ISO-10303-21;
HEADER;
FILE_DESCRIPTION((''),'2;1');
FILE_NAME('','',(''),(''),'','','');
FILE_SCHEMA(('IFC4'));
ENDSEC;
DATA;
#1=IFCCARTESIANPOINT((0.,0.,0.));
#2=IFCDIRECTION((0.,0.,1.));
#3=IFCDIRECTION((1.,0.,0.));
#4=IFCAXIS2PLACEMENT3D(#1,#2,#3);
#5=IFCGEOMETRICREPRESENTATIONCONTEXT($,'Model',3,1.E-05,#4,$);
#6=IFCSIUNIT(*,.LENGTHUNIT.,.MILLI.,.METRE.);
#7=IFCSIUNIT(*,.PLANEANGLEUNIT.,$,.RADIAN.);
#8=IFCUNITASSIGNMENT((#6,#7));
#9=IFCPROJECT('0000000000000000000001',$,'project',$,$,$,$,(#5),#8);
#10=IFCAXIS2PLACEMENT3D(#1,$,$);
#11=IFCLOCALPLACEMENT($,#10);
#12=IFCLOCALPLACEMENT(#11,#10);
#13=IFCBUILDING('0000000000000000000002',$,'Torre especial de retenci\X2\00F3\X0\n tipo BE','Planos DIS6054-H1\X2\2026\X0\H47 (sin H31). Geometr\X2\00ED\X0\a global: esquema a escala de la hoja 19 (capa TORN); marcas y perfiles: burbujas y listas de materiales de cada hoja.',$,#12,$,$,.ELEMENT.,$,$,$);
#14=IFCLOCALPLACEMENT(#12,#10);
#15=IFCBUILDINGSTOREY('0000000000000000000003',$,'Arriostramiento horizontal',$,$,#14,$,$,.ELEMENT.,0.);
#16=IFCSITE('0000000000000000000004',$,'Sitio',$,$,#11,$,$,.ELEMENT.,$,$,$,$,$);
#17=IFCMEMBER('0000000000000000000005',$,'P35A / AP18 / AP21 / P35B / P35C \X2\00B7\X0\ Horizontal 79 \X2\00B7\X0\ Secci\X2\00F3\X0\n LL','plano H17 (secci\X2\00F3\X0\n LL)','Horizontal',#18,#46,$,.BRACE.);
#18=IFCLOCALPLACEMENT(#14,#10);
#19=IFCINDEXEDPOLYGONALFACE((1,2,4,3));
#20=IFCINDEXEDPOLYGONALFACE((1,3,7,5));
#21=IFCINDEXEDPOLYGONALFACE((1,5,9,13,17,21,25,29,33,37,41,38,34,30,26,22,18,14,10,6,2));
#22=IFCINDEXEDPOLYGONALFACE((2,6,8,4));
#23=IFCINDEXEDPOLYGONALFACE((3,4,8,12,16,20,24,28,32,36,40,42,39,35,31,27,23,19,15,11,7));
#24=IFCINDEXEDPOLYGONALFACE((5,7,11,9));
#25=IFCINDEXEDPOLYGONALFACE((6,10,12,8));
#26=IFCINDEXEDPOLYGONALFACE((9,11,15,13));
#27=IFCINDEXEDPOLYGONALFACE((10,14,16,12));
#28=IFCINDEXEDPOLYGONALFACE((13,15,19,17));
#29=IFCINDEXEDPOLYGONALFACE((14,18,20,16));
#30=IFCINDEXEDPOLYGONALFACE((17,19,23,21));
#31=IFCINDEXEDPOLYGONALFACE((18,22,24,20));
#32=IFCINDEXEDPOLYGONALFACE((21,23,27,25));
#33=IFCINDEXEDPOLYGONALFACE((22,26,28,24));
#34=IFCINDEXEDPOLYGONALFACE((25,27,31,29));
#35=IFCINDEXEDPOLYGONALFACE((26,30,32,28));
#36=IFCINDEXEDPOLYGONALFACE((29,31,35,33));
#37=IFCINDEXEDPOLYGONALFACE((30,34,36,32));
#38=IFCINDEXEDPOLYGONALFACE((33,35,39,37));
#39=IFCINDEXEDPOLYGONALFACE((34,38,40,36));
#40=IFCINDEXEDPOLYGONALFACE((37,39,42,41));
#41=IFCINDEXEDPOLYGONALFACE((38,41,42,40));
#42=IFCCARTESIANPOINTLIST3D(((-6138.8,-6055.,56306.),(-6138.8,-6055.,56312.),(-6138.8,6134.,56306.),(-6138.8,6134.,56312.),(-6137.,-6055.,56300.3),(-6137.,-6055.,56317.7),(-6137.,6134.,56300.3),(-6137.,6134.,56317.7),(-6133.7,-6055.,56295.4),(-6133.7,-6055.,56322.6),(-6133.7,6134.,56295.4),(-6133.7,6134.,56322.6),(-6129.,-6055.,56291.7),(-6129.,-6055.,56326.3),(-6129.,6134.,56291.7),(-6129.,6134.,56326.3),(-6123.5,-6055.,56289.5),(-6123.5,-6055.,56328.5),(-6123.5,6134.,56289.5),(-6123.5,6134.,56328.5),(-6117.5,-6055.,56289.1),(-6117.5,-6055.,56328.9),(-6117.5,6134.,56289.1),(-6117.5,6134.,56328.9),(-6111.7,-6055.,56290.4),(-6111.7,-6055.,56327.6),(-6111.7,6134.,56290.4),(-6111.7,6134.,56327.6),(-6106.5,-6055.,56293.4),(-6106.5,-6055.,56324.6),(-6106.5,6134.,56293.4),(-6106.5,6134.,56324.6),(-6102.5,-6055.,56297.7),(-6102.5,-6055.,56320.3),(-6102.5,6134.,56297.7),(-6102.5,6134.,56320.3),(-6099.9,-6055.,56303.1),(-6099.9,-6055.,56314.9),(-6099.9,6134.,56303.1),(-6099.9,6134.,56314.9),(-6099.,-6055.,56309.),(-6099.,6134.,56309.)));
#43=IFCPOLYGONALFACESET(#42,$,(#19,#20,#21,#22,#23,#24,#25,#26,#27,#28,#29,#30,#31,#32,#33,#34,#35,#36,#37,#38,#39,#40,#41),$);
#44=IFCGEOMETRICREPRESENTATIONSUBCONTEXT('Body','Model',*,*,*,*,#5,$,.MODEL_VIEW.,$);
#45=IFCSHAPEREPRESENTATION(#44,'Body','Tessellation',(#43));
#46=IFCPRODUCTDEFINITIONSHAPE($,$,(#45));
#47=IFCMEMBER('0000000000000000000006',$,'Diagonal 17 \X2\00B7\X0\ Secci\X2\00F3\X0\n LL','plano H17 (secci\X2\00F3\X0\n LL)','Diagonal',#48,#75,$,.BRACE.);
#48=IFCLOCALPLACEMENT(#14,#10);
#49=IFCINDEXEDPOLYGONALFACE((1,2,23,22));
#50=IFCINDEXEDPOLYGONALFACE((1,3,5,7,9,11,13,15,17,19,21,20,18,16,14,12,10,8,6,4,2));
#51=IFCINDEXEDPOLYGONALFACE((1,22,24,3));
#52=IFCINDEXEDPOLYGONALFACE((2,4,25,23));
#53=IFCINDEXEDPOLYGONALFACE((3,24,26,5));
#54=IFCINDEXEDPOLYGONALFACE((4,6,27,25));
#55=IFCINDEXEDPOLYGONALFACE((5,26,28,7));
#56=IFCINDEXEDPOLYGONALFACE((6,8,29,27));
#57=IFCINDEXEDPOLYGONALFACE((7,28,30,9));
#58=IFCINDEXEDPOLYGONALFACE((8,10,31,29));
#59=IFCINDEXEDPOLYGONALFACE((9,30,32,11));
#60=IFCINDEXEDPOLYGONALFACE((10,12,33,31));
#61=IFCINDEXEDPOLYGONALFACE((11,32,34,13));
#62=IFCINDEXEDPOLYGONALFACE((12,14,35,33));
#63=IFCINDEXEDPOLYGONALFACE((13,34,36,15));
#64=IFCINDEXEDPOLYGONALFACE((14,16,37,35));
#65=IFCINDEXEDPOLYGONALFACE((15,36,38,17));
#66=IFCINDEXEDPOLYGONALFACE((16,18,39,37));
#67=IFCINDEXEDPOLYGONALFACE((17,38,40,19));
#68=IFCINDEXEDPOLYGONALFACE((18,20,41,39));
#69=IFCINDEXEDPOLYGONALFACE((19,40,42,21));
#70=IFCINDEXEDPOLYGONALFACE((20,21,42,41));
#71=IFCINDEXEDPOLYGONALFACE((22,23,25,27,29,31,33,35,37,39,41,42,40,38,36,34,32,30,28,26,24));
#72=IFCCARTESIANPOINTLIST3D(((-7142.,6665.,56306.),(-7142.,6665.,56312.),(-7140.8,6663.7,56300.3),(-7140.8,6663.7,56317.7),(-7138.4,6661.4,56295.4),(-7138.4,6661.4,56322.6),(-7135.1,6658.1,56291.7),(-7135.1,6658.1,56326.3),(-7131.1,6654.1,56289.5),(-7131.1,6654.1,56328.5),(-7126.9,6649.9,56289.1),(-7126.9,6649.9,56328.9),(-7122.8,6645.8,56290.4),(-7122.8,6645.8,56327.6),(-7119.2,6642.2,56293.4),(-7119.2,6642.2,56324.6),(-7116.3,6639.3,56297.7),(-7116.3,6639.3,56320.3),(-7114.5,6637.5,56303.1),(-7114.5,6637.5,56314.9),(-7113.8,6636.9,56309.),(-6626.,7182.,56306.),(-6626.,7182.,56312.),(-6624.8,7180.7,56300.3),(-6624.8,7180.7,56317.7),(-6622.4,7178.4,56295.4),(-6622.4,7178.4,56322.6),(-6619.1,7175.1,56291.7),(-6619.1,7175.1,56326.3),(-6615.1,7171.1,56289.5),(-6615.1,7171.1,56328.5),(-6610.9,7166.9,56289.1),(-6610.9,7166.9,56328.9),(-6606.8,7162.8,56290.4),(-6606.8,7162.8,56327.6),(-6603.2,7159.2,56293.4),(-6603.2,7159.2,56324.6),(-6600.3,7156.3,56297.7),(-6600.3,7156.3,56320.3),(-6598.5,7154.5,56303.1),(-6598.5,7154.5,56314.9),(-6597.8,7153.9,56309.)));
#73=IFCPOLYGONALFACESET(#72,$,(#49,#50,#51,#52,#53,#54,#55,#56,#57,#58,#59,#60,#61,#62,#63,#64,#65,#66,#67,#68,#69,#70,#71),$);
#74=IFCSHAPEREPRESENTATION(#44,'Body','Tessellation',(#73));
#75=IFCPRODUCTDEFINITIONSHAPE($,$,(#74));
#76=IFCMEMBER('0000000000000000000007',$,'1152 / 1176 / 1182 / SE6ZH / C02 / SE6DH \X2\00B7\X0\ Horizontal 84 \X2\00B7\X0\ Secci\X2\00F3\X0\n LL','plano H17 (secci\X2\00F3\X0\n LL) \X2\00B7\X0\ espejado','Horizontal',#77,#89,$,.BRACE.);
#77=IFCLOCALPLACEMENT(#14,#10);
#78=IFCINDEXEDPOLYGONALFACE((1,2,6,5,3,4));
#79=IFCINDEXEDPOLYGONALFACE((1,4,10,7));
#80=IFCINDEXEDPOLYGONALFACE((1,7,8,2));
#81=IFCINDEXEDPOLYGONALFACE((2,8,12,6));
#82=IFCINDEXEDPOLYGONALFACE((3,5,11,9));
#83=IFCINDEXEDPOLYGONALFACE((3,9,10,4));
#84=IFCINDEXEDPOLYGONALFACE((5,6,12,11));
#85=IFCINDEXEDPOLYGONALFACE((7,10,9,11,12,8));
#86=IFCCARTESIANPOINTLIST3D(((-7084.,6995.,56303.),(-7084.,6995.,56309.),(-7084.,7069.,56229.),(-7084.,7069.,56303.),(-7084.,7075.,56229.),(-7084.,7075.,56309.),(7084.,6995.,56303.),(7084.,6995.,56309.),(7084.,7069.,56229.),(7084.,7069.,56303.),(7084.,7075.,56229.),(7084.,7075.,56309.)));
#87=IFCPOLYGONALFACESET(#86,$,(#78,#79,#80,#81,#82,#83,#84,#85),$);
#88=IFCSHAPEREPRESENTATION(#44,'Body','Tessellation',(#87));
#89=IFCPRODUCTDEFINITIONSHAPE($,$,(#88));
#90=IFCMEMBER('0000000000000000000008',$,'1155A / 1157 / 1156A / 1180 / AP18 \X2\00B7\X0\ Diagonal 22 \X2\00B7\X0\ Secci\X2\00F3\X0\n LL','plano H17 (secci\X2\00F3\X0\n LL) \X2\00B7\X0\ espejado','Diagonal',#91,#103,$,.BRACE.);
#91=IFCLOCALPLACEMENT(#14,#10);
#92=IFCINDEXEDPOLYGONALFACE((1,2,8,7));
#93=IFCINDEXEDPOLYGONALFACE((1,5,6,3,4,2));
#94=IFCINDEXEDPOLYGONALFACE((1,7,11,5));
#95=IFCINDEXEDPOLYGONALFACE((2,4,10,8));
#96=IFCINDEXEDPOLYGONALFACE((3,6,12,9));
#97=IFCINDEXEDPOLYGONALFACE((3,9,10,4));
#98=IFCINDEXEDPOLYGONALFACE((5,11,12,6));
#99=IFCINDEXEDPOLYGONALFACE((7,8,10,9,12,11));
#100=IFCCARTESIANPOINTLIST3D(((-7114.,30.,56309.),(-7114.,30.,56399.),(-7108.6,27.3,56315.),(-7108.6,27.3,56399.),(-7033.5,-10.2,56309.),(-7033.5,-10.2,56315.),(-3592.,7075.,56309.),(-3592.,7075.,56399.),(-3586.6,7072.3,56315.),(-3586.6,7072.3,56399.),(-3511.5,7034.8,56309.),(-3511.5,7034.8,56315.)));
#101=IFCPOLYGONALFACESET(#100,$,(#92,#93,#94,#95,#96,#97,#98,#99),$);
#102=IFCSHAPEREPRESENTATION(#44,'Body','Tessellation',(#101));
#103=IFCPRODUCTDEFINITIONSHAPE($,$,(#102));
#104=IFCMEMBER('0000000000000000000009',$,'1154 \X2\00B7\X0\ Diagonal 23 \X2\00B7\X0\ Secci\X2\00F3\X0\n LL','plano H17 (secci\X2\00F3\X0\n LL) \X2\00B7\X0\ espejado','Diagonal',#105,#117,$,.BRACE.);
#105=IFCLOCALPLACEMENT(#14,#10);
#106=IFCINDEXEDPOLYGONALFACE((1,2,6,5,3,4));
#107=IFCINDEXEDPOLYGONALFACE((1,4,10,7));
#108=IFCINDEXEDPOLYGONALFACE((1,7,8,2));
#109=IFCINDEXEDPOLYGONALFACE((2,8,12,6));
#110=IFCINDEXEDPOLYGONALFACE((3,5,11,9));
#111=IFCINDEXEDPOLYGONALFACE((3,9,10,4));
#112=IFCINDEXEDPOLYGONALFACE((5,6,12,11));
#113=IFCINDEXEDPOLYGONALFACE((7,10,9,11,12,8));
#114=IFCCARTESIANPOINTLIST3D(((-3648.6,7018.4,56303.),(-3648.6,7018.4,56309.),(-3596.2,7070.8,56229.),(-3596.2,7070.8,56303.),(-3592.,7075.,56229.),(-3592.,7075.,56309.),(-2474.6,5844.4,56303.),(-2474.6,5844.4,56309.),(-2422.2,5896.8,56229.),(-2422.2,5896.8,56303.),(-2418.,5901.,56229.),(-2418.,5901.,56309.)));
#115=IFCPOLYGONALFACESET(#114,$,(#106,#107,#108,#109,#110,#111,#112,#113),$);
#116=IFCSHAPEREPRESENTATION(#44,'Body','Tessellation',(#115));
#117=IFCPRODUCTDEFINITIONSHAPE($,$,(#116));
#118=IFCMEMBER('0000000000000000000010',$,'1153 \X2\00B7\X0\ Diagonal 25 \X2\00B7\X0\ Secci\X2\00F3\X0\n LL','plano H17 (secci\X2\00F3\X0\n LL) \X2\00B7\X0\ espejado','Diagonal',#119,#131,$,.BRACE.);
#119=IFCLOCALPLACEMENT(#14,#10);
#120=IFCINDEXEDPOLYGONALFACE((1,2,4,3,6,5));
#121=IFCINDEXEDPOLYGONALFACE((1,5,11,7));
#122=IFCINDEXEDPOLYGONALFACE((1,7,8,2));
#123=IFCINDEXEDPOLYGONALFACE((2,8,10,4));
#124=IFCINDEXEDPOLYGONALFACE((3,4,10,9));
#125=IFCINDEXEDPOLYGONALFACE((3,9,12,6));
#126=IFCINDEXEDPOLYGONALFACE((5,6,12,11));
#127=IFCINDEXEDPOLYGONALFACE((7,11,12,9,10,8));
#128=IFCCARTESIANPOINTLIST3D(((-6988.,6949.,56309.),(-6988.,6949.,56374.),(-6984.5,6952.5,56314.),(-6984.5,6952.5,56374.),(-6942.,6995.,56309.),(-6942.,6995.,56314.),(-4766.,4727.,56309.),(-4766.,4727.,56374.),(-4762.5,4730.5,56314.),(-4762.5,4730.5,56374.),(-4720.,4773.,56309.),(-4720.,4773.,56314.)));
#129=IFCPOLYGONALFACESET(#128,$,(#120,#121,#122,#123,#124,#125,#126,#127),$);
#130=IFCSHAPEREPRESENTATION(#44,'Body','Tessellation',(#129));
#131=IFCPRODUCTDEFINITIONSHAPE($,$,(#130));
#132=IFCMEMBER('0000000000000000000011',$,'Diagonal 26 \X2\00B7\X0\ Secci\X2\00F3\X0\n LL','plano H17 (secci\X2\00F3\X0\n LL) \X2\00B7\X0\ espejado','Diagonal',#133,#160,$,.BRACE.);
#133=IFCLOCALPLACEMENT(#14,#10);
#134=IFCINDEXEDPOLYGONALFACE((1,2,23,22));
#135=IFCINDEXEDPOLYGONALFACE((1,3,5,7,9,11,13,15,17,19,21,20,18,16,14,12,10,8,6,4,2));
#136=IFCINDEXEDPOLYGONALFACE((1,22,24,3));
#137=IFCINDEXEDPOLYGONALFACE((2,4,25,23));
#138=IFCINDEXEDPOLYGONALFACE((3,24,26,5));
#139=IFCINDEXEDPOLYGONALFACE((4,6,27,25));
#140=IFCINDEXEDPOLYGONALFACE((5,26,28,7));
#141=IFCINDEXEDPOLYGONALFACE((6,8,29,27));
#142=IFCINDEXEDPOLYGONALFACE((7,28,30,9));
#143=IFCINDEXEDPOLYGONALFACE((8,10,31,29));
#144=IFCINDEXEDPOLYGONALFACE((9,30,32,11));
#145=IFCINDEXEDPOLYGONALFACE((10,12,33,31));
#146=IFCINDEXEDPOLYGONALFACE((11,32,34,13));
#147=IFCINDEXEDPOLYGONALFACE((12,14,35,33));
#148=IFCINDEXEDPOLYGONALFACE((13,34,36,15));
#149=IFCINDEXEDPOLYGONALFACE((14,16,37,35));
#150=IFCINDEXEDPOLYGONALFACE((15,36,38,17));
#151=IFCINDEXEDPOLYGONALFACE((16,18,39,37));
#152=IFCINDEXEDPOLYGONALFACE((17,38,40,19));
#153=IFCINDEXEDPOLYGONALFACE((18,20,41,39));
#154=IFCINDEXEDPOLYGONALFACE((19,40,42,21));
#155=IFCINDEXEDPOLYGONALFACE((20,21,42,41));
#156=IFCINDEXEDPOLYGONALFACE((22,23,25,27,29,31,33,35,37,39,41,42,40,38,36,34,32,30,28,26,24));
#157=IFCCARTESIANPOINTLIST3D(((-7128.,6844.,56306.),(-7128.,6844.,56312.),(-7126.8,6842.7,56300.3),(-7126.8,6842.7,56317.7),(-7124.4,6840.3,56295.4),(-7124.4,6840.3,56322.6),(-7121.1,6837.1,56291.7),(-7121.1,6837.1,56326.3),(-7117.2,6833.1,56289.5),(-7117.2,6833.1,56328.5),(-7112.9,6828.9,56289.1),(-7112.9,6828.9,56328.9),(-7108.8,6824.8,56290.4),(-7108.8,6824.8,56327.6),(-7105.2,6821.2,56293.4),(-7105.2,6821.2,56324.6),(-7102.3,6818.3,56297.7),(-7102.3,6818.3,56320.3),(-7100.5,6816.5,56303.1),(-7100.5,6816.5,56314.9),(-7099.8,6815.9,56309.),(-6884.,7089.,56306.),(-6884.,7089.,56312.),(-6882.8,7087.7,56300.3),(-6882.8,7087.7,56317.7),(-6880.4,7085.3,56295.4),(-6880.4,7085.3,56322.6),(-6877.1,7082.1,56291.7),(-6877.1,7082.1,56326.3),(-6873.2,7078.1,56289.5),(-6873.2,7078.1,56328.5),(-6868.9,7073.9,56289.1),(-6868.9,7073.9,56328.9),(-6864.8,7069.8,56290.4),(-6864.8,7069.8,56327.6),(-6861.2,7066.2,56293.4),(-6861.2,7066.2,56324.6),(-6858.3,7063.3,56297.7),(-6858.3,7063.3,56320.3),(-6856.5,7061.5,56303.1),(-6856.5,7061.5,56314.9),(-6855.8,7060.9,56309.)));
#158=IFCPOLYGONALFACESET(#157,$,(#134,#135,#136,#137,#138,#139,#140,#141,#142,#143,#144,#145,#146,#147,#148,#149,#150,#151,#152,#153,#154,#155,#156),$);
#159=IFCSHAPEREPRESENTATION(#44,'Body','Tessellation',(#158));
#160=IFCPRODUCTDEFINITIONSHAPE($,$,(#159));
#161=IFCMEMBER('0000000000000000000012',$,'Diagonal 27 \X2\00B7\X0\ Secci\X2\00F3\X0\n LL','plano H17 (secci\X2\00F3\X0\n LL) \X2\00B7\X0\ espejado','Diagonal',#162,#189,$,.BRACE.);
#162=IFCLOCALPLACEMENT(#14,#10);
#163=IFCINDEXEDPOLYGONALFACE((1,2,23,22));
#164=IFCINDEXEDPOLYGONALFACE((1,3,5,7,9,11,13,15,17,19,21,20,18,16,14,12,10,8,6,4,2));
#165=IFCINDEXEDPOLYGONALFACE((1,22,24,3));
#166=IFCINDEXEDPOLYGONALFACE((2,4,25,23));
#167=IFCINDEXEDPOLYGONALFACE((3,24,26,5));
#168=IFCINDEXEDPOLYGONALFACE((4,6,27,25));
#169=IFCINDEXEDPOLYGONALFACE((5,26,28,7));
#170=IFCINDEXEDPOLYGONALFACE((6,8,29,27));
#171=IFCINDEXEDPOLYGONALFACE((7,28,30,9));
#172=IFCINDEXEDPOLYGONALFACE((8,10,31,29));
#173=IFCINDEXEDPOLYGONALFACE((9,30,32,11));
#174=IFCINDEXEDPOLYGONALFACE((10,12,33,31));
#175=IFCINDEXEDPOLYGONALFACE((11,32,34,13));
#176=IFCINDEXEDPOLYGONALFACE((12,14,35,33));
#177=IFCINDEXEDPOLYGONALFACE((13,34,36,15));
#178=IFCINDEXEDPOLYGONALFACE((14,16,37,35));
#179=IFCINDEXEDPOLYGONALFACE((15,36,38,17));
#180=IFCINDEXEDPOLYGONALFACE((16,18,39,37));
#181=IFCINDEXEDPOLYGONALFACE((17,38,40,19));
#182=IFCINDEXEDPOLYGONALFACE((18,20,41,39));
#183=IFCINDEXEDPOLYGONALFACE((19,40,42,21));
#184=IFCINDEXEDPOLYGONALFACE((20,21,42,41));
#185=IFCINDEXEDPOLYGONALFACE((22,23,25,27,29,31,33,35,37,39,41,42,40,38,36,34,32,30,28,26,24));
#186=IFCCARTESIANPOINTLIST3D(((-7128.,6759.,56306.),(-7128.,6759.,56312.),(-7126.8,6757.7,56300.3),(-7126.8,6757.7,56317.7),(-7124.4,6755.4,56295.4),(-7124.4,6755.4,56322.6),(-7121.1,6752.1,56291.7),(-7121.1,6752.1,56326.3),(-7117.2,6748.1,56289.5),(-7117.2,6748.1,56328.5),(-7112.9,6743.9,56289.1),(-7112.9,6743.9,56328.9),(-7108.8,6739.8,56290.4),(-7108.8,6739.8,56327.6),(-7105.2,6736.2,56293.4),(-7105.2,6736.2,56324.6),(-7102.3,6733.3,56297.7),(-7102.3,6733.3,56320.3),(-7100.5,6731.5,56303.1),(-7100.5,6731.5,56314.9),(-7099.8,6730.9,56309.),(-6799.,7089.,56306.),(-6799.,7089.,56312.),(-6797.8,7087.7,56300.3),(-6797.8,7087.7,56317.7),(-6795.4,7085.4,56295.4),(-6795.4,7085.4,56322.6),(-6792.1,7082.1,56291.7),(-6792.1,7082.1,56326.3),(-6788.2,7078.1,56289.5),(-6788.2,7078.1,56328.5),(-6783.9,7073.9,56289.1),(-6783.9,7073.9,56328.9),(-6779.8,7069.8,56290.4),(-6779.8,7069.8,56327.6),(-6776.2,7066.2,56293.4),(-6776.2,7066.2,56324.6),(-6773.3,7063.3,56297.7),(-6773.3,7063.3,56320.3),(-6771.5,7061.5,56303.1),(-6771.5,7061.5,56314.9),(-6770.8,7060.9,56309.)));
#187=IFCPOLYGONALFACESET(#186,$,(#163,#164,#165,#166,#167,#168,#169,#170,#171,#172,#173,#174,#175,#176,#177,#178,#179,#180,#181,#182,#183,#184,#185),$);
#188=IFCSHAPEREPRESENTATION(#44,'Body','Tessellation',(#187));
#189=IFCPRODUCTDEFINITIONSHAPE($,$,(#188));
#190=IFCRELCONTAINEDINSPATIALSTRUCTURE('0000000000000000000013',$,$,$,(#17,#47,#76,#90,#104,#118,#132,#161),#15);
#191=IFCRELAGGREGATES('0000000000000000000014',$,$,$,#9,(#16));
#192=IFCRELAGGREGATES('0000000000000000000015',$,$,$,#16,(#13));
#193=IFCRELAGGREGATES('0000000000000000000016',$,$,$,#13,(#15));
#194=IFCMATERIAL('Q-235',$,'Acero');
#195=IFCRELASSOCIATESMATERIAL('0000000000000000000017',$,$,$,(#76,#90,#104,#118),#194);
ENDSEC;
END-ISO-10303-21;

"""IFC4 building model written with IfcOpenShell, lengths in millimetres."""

from ifc_helpers import new_model, si_unit, frame, frame_2d, origin, origin_with_axes, place, context, subcontext, project, spatial, circle, l_section, extrude, material, element, save


model = new_model("IFC4")

# Units and contexts
model_context = context("Model", 3, precision=1e-05, world=origin_with_axes())
body_context = subcontext(model_context, "Body", "Model", "MODEL_VIEW")
ifc_project = project(units=[si_unit("LENGTHUNIT", "METRE", prefix="MILLI"), si_unit("PLANEANGLEUNIT", "RADIAN")], contexts=[model_context])

# Site, building, storey
site_placement = place(None, origin())
site = spatial("IfcSite", under=ifc_project, at=site_placement, Name="Sitio", CompositionType="ELEMENT")
building_placement = place(site_placement, origin())
building = spatial("IfcBuilding", under=site, at=building_placement, Name="Torre especial de retención tipo BE", Description="Planos DIS6054-H1…H47 (sin H31). Geometría global: esquema a escala de la hoja 19 (capa TORN); marcas y perfiles: burbujas y listas de materiales de cada hoja.", CompositionType="ELEMENT")
storey_placement = place(building_placement, origin())
storey = spatial("IfcBuildingStorey", under=building, at=storey_placement, Name="Arriostramiento horizontal", CompositionType="ELEMENT", Elevation=0.0)

# Members
member_1_placement = place(storey_placement, frame((-6119.0, 6134.0, 56309.0), z_axis=(0.0, -1.0, 0.0), x_axis=(1.0, 0.0, 0.0)))
element("IfcMember", 1, at=member_1_placement, inside=storey, Name="P35A / AP18 / AP21 / P35B / P35C · Horizontal 79 · Sección LL", Description="plano H17 (sección LL)", ObjectType="Horizontal", PredefinedType="BRACE", context=body_context, shape_type="SweptSolid", body=[
    extrude(circle(Radius=20.0), None, (0.0, 0.0, 1.0), 12189.0),
])
member_2_placement = place(storey_placement, frame((-6612.0, 7168.0, 56309.0), z_axis=(-0.706422, -0.707791, 0.0), x_axis=(0.707791, -0.706422, 0.0)))
element("IfcMember", 2, at=member_2_placement, inside=storey, Name="Diagonal 17 · Sección LL", Description="plano H17 (sección LL)", ObjectType="Diagonal", PredefinedType="BRACE", context=body_context, shape_type="SweptSolid", body=[
    extrude(circle(Radius=20.0), None, (0.0, 0.0, 1.0), 730.4),
])
ifc_material = material(Name="Q-235", Category="Acero")
member_3_placement = place(storey_placement, frame((-7084.0, 7075.0, 56309.0), z_axis=(1.0, 0.0, 0.0), x_axis=(0.0, -1.0, 0.0)))
element("IfcMember", 3, at=member_3_placement, inside=storey, material=ifc_material, Name="1152 / 1176 / 1182 / SE6ZH / C02 / SE6DH · Horizontal 84 · Sección LL", Description="plano H17 (sección LL) · espejado", ObjectType="Horizontal", PredefinedType="BRACE", context=body_context, shape_type="SweptSolid", body=[
    extrude(l_section(Depth=80.0, Width=80.0, Thickness=6.0, at=frame_2d((40.0, 40.0))), None, (0.0, 0.0, 1.0), 14168.0),
])
member_4_placement = place(storey_placement, frame((-3592.0, 7075.0, 56309.0), z_axis=(-0.447163, -0.894453, 0.0), x_axis=(0.894453, -0.447163, 0.0)))
element("IfcMember", 4, at=member_4_placement, inside=storey, material=ifc_material, Name="1155A / 1157 / 1156A / 1180 / AP18 · Diagonal 22 · Sección LL", Description="plano H17 (sección LL) · espejado", ObjectType="Diagonal", PredefinedType="BRACE", context=body_context, shape_type="SweptSolid", body=[
    extrude(l_section(Depth=90.0, Width=90.0, Thickness=6.0, at=frame_2d((45.0, 45.0))), None, (0.0, 0.0, 1.0), 7876.3),
])
member_5_placement = place(storey_placement, frame((-3592.0, 7075.0, 56309.0), z_axis=(0.707107, -0.707107, 0.0), x_axis=(-0.707107, -0.707107, 0.0)))
element("IfcMember", 5, at=member_5_placement, inside=storey, material=ifc_material, Name="1154 · Diagonal 23 · Sección LL", Description="plano H17 (sección LL) · espejado", ObjectType="Diagonal", PredefinedType="BRACE", context=body_context, shape_type="SweptSolid", body=[
    extrude(l_section(Depth=80.0, Width=80.0, Thickness=6.0, at=frame_2d((40.0, 40.0))), None, (0.0, 0.0, 1.0), 1660.3),
])
member_6_placement = place(storey_placement, frame((-6988.0, 6949.0, 56309.0), z_axis=(0.707107, -0.707107, 0.0), x_axis=(0.707107, 0.707107, 0.0)))
element("IfcMember", 6, at=member_6_placement, inside=storey, material=ifc_material, Name="1153 · Diagonal 25 · Sección LL", Description="plano H17 (sección LL) · espejado", ObjectType="Diagonal", PredefinedType="BRACE", context=body_context, shape_type="SweptSolid", body=[
    extrude(l_section(Depth=65.0, Width=65.0, Thickness=5.0, at=frame_2d((32.5, 32.5))), None, (0.0, 0.0, 1.0), 3142.4),
])
member_7_placement = place(storey_placement, frame((-6870.0, 7075.0, 56309.0), z_axis=(-0.705659, -0.708551, 0.0), x_axis=(0.708551, -0.705659, 0.0)))
element("IfcMember", 7, at=member_7_placement, inside=storey, Name="Diagonal 26 · Sección LL", Description="plano H17 (sección LL) · espejado", ObjectType="Diagonal", PredefinedType="BRACE", context=body_context, shape_type="SweptSolid", body=[
    extrude(circle(Radius=20.0), None, (0.0, 0.0, 1.0), 345.8),
])
member_8_placement = place(storey_placement, frame((-6785.0, 7075.0, 56309.0), z_axis=(-0.706033, -0.708179, 0.0), x_axis=(0.708179, -0.706033, 0.0)))
element("IfcMember", 8, at=member_8_placement, inside=storey, Name="Diagonal 27 · Sección LL", Description="plano H17 (sección LL) · espejado", ObjectType="Diagonal", PredefinedType="BRACE", context=body_context, shape_type="SweptSolid", body=[
    extrude(circle(Radius=20.0), None, (0.0, 0.0, 1.0), 466.0),
])

save(model, "model.ifc")
